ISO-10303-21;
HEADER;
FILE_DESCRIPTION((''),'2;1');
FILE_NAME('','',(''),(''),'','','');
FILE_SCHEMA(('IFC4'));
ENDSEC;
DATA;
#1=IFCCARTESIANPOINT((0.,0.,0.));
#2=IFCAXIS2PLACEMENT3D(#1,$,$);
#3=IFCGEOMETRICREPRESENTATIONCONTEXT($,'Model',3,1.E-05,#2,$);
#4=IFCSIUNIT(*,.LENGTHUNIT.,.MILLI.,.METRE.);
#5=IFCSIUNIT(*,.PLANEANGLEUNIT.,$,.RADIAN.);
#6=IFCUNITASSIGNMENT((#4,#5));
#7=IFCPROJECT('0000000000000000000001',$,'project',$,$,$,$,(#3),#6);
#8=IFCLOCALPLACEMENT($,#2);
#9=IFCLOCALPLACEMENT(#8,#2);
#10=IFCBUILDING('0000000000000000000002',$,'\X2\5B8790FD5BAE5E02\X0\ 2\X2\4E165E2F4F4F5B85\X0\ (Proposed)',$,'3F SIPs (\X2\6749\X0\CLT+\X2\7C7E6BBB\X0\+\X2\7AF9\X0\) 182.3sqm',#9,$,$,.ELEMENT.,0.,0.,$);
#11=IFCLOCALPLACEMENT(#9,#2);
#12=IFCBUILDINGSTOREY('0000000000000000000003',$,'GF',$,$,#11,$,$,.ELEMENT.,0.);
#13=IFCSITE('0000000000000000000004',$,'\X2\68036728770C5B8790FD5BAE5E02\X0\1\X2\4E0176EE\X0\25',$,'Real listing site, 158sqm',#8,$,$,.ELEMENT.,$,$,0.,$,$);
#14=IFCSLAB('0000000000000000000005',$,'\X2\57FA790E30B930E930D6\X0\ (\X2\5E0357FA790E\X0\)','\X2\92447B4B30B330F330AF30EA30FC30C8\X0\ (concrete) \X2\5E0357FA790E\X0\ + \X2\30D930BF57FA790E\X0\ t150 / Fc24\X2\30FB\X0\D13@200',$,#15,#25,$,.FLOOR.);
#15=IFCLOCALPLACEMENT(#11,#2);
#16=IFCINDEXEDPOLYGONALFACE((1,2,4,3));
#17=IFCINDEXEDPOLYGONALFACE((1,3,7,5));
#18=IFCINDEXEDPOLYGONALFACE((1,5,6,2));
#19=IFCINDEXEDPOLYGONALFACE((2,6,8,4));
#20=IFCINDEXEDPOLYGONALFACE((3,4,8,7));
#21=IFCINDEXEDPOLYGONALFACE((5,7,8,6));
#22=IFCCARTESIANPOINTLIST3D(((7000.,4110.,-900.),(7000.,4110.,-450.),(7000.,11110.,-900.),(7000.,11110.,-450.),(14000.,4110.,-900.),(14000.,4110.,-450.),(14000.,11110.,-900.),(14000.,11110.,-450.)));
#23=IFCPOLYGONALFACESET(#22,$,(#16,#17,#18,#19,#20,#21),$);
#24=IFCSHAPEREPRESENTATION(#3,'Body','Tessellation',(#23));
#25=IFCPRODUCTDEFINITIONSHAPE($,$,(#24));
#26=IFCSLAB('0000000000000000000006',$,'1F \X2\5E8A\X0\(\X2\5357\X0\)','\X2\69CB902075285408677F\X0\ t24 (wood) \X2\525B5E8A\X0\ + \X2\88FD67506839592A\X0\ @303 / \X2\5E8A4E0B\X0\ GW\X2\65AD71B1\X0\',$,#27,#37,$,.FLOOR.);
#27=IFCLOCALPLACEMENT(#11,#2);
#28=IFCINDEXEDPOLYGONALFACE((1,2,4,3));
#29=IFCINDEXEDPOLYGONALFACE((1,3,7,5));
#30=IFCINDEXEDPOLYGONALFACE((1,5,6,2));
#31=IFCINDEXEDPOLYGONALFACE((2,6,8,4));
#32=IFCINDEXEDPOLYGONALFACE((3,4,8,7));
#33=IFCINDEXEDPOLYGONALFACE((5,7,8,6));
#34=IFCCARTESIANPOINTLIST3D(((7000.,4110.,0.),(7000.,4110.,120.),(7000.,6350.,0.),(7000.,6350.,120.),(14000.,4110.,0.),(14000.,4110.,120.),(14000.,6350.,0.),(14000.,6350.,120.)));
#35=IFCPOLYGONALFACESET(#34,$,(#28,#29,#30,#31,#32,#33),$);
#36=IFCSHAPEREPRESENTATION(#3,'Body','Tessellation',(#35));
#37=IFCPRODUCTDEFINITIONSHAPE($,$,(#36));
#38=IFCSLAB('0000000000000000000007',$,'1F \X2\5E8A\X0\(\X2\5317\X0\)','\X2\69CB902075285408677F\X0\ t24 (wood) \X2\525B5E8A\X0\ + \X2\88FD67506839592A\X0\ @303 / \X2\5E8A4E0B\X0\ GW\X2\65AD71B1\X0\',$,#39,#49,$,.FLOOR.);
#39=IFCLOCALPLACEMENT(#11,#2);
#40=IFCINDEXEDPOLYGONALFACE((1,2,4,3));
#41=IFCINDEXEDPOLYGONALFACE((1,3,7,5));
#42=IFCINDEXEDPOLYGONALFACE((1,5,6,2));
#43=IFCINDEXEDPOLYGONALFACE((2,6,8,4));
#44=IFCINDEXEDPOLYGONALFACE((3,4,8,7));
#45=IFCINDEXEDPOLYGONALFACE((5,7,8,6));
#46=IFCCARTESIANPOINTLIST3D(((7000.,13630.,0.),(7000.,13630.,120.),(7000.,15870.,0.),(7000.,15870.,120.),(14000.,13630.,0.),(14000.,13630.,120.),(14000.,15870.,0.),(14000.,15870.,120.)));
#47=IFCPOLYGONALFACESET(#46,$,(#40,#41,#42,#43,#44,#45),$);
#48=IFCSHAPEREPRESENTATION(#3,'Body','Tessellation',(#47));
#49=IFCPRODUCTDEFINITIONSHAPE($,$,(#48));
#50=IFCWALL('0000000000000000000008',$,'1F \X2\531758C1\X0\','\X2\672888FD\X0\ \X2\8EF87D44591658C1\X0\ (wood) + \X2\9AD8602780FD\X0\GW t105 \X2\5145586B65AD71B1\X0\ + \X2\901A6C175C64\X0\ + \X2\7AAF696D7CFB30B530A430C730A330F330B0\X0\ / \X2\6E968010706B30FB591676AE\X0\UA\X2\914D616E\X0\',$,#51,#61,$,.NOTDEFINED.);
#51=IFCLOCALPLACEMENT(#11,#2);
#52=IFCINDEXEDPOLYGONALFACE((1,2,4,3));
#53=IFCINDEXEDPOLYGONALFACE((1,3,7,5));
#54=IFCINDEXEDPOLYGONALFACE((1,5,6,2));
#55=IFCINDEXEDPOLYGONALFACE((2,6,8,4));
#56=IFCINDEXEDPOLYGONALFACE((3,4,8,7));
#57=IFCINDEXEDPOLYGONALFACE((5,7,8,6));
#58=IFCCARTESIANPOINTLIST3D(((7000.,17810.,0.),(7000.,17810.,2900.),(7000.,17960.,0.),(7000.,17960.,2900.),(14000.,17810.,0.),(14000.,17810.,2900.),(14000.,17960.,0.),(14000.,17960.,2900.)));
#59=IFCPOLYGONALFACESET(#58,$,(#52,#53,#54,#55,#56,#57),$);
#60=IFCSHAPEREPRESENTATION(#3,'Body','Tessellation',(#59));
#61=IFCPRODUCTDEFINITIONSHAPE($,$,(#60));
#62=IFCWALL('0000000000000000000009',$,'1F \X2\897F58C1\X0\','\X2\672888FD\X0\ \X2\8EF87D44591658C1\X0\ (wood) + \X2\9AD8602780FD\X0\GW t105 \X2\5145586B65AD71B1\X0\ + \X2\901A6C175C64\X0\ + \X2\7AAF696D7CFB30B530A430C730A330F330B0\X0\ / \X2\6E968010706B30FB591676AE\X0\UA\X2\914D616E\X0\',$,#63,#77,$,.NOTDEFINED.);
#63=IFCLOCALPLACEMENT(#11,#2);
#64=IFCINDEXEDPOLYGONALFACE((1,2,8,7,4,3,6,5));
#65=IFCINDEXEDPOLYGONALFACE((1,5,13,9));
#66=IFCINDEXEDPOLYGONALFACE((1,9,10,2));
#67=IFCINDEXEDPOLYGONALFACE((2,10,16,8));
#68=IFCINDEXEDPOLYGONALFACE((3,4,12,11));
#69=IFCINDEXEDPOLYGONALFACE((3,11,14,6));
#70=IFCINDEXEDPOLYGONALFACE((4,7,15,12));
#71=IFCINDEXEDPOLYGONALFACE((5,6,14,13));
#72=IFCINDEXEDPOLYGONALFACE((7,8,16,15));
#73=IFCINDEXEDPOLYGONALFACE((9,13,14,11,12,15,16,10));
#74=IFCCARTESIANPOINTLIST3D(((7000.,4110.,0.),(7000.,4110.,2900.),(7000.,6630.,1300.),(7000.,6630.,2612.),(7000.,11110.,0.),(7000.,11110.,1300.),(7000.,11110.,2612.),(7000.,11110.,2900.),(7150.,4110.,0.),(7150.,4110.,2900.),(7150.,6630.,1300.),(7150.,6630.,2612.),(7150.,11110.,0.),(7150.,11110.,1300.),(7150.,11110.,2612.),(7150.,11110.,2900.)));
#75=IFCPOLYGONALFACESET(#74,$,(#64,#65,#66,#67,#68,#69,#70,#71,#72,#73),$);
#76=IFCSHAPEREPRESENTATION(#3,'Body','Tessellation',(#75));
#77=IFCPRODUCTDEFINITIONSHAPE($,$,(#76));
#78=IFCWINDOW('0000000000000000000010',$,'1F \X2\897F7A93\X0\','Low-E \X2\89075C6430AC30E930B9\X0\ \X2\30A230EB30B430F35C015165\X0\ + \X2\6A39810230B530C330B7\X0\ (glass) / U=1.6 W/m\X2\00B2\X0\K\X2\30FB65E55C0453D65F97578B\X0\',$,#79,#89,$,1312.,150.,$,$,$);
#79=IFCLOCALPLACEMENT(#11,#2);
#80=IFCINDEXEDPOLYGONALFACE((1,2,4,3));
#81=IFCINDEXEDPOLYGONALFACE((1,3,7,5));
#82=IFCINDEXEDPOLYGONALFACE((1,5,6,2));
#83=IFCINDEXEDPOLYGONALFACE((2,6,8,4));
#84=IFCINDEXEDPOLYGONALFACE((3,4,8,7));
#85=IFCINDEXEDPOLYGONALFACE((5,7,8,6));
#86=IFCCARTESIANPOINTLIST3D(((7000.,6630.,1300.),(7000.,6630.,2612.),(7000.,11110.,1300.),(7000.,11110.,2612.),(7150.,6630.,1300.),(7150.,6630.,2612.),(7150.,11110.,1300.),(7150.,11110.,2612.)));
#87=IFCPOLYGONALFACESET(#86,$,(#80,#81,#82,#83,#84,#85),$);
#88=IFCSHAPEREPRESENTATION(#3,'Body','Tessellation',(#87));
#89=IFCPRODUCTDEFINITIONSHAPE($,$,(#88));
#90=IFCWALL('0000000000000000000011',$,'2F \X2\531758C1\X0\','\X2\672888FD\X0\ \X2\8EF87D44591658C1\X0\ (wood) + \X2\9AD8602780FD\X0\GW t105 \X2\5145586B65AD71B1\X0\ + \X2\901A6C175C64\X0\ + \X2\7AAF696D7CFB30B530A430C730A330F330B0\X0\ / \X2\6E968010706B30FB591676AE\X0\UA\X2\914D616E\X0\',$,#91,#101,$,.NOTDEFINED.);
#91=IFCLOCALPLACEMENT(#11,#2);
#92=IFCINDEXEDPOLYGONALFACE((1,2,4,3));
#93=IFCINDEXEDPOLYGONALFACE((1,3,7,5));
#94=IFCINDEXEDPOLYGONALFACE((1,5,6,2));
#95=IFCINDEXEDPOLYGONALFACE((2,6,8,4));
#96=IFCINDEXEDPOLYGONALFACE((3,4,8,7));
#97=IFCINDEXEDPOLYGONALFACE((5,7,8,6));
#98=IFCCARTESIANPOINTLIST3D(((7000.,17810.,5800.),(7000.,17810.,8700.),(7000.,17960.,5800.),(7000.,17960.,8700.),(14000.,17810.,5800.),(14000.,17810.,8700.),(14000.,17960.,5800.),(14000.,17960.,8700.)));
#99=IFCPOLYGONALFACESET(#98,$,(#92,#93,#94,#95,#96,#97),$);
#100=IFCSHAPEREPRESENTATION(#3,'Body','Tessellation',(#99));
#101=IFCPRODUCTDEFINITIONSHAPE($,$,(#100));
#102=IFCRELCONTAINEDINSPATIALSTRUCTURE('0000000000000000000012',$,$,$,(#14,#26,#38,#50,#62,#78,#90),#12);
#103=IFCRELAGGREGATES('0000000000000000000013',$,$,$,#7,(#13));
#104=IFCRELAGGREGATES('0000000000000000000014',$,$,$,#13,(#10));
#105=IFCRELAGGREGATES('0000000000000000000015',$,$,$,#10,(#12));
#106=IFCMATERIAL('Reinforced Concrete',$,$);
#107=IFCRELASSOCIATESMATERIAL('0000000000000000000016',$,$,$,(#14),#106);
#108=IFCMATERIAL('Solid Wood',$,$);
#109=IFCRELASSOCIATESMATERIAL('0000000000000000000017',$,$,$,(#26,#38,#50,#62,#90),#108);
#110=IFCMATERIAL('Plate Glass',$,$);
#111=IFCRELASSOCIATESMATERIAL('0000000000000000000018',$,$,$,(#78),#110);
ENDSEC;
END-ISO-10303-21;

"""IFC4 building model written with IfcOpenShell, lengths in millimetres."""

from ifc_helpers import new_model, si_unit, frame, frame_2d, origin, place, context, project, spatial, rectangle, extrude, material, element, fill, save


model = new_model("IFC4")

# Units and contexts
model_context = context("Model", 3, precision=1e-05, world=origin())
ifc_project = project(units=[si_unit("LENGTHUNIT", "METRE", prefix="MILLI"), si_unit("PLANEANGLEUNIT", "RADIAN")], contexts=[model_context])

# Site, building, storey
site_placement = place(None, origin())
site = spatial("IfcSite", under=ifc_project, at=site_placement, Name="栃木県宇都宮市1丁目25", ObjectType="Real listing site, 158sqm", CompositionType="ELEMENT", RefElevation=0.0)
building_placement = place(site_placement, origin())
building = spatial("IfcBuilding", under=site, at=building_placement, Name="宇都宮市 2世帯住宅 (Proposed)", ObjectType="3F SIPs (杉CLT+籾殻+竹) 182.3sqm", CompositionType="ELEMENT", ElevationOfRefHeight=0.0, ElevationOfTerrain=0.0)
storey_placement = place(building_placement, origin())
storey = spatial("IfcBuildingStorey", under=building, at=storey_placement, Name="GF", CompositionType="ELEMENT", Elevation=0.0)

# Slabs
ifc_material_1 = material(Name="Reinforced Concrete")
slab_1_placement = place(storey_placement, frame((3500.0, 2055.0, -450.0)))
element("IfcSlab", 1, at=slab_1_placement, inside=storey, material=ifc_material_1, Name="基礎スラブ (布基礎)", Description="鉄筋コンクリート (concrete) 布基礎 + ベタ基礎 t150 / Fc24・D13@200", PredefinedType="FLOOR", context=model_context, shape_type="SweptSolid", body=[
    extrude(rectangle(XDim=7000.0, YDim=7000.0, at=frame_2d((3500.0, 3500.0))), frame((3500.0, 2055.0, -450.0)), (0.0, 0.0, 1.0), 450.0),
])
ifc_material_2 = material(Name="Solid Wood")
slab_2_placement = place(storey_placement, frame((3500.0, 2055.0, 0.0)))
element("IfcSlab", 2, at=slab_2_placement, inside=storey, material=ifc_material_2, Name="1F 床(南)", Description="構造用合板 t24 (wood) 剛床 + 製材根太 @303 / 床下 GW断熱", PredefinedType="FLOOR", context=model_context, shape_type="SweptSolid", body=[
    extrude(rectangle(XDim=7000.0, YDim=2240.0, at=frame_2d((3500.0, 1120.0))), frame((3500.0, 2055.0, 0.0)), (0.0, 0.0, 1.0), 120.0),
])
slab_3_placement = place(storey_placement, frame((3500.0, 6815.0, 0.0)))
element("IfcSlab", 3, at=slab_3_placement, inside=storey, material=ifc_material_2, Name="1F 床(北)", Description="構造用合板 t24 (wood) 剛床 + 製材根太 @303 / 床下 GW断熱", PredefinedType="FLOOR", context=model_context, shape_type="SweptSolid", body=[
    extrude(rectangle(XDim=7000.0, YDim=2240.0, at=frame_2d((3500.0, 1120.0))), frame((3500.0, 6815.0, 0.0)), (0.0, 0.0, 1.0), 120.0),
])

# Shared definitions
ifc_material_3 = material(Name="Plate Glass")

# Wall
wall_1_placement = place(storey_placement, frame((3500.0, 8905.0, 0.0)))
element("IfcWall", 4, at=wall_1_placement, inside=storey, material=ifc_material_2, Name="1F 北壁", Description="木製 軸組外壁 (wood) + 高性能GW t105 充填断熱 + 通気層 + 窯業系サイディング / 準耐火・外皮UA配慮", PredefinedType="NOTDEFINED", context=model_context, shape_type="SweptSolid", body=[
    extrude(rectangle(XDim=7000.0, YDim=150.0, at=frame_2d((3500.0, 75.0))), frame((3500.0, 8905.0, 0.0)), (0.0, 0.0, 1.0), 2900.0),
])

# Wall, opening, window
wall_2_placement = place(storey_placement, frame((3500.0, 2055.0, 0.0)))
wall_2 = element("IfcWall", 5, at=wall_2_placement, inside=storey, material=ifc_material_2, Name="1F 西壁", Description="木製 軸組外壁 (wood) + 高性能GW t105 充填断熱 + 通気層 + 窯業系サイディング / 準耐火・外皮UA配慮", PredefinedType="NOTDEFINED", context=model_context, shape_type="SweptSolid", body=[
    extrude(rectangle(XDim=150.0, YDim=7000.0, at=frame_2d((75.0, 3500.0))), frame((3500.0, 2055.0, 0.0)), (0.0, 0.0, 1.0), 2900.0),
])
opening_1_placement = place(storey_placement, frame((3500.0, 3315.0, 650.0)))
opening_1 = element("IfcOpeningElement", 6, at=opening_1_placement, cuts=wall_2, PredefinedType="NOTDEFINED", context=model_context, shape_type="SweptSolid", body=[
    extrude(rectangle(XDim=150.0, YDim=4480.0, at=frame_2d((75.0, 2240.0))), frame((3500.0, 3315.0, 650.0)), (0.0, 0.0, 1.0), 1312.0),
])
window_1_placement = place(storey_placement, frame((3500.0, 3315.0, 650.0)))
window_1 = element("IfcWindow", 7, at=window_1_placement, inside=storey, material=ifc_material_3, Name="1F 西窓", Description="Low-E 複層ガラス アルゴン封入 + 樹脂サッシ (glass) / U=1.6 W/m²K・日射取得型", OverallHeight=1312.0, OverallWidth=150.0, context=model_context, shape_type="SweptSolid", body=[
    extrude(rectangle(XDim=150.0, YDim=4480.0, at=frame_2d((75.0, 2240.0))), frame((3500.0, 3315.0, 650.0)), (0.0, 0.0, 1.0), 1312.0),
])
fill(opening_1, window_1)

# Wall
wall_3_placement = place(storey_placement, frame((3500.0, 8905.0, 2900.0)))
element("IfcWall", 8, at=wall_3_placement, inside=storey, material=ifc_material_2, Name="2F 北壁", Description="木製 軸組外壁 (wood) + 高性能GW t105 充填断熱 + 通気層 + 窯業系サイディング / 準耐火・外皮UA配慮", PredefinedType="NOTDEFINED", context=model_context, shape_type="SweptSolid", body=[
    extrude(rectangle(XDim=7000.0, YDim=150.0, at=frame_2d((3500.0, 75.0))), frame((3500.0, 8905.0, 2900.0)), (0.0, 0.0, 1.0), 2900.0),
])

save(model, "model.ifc")
